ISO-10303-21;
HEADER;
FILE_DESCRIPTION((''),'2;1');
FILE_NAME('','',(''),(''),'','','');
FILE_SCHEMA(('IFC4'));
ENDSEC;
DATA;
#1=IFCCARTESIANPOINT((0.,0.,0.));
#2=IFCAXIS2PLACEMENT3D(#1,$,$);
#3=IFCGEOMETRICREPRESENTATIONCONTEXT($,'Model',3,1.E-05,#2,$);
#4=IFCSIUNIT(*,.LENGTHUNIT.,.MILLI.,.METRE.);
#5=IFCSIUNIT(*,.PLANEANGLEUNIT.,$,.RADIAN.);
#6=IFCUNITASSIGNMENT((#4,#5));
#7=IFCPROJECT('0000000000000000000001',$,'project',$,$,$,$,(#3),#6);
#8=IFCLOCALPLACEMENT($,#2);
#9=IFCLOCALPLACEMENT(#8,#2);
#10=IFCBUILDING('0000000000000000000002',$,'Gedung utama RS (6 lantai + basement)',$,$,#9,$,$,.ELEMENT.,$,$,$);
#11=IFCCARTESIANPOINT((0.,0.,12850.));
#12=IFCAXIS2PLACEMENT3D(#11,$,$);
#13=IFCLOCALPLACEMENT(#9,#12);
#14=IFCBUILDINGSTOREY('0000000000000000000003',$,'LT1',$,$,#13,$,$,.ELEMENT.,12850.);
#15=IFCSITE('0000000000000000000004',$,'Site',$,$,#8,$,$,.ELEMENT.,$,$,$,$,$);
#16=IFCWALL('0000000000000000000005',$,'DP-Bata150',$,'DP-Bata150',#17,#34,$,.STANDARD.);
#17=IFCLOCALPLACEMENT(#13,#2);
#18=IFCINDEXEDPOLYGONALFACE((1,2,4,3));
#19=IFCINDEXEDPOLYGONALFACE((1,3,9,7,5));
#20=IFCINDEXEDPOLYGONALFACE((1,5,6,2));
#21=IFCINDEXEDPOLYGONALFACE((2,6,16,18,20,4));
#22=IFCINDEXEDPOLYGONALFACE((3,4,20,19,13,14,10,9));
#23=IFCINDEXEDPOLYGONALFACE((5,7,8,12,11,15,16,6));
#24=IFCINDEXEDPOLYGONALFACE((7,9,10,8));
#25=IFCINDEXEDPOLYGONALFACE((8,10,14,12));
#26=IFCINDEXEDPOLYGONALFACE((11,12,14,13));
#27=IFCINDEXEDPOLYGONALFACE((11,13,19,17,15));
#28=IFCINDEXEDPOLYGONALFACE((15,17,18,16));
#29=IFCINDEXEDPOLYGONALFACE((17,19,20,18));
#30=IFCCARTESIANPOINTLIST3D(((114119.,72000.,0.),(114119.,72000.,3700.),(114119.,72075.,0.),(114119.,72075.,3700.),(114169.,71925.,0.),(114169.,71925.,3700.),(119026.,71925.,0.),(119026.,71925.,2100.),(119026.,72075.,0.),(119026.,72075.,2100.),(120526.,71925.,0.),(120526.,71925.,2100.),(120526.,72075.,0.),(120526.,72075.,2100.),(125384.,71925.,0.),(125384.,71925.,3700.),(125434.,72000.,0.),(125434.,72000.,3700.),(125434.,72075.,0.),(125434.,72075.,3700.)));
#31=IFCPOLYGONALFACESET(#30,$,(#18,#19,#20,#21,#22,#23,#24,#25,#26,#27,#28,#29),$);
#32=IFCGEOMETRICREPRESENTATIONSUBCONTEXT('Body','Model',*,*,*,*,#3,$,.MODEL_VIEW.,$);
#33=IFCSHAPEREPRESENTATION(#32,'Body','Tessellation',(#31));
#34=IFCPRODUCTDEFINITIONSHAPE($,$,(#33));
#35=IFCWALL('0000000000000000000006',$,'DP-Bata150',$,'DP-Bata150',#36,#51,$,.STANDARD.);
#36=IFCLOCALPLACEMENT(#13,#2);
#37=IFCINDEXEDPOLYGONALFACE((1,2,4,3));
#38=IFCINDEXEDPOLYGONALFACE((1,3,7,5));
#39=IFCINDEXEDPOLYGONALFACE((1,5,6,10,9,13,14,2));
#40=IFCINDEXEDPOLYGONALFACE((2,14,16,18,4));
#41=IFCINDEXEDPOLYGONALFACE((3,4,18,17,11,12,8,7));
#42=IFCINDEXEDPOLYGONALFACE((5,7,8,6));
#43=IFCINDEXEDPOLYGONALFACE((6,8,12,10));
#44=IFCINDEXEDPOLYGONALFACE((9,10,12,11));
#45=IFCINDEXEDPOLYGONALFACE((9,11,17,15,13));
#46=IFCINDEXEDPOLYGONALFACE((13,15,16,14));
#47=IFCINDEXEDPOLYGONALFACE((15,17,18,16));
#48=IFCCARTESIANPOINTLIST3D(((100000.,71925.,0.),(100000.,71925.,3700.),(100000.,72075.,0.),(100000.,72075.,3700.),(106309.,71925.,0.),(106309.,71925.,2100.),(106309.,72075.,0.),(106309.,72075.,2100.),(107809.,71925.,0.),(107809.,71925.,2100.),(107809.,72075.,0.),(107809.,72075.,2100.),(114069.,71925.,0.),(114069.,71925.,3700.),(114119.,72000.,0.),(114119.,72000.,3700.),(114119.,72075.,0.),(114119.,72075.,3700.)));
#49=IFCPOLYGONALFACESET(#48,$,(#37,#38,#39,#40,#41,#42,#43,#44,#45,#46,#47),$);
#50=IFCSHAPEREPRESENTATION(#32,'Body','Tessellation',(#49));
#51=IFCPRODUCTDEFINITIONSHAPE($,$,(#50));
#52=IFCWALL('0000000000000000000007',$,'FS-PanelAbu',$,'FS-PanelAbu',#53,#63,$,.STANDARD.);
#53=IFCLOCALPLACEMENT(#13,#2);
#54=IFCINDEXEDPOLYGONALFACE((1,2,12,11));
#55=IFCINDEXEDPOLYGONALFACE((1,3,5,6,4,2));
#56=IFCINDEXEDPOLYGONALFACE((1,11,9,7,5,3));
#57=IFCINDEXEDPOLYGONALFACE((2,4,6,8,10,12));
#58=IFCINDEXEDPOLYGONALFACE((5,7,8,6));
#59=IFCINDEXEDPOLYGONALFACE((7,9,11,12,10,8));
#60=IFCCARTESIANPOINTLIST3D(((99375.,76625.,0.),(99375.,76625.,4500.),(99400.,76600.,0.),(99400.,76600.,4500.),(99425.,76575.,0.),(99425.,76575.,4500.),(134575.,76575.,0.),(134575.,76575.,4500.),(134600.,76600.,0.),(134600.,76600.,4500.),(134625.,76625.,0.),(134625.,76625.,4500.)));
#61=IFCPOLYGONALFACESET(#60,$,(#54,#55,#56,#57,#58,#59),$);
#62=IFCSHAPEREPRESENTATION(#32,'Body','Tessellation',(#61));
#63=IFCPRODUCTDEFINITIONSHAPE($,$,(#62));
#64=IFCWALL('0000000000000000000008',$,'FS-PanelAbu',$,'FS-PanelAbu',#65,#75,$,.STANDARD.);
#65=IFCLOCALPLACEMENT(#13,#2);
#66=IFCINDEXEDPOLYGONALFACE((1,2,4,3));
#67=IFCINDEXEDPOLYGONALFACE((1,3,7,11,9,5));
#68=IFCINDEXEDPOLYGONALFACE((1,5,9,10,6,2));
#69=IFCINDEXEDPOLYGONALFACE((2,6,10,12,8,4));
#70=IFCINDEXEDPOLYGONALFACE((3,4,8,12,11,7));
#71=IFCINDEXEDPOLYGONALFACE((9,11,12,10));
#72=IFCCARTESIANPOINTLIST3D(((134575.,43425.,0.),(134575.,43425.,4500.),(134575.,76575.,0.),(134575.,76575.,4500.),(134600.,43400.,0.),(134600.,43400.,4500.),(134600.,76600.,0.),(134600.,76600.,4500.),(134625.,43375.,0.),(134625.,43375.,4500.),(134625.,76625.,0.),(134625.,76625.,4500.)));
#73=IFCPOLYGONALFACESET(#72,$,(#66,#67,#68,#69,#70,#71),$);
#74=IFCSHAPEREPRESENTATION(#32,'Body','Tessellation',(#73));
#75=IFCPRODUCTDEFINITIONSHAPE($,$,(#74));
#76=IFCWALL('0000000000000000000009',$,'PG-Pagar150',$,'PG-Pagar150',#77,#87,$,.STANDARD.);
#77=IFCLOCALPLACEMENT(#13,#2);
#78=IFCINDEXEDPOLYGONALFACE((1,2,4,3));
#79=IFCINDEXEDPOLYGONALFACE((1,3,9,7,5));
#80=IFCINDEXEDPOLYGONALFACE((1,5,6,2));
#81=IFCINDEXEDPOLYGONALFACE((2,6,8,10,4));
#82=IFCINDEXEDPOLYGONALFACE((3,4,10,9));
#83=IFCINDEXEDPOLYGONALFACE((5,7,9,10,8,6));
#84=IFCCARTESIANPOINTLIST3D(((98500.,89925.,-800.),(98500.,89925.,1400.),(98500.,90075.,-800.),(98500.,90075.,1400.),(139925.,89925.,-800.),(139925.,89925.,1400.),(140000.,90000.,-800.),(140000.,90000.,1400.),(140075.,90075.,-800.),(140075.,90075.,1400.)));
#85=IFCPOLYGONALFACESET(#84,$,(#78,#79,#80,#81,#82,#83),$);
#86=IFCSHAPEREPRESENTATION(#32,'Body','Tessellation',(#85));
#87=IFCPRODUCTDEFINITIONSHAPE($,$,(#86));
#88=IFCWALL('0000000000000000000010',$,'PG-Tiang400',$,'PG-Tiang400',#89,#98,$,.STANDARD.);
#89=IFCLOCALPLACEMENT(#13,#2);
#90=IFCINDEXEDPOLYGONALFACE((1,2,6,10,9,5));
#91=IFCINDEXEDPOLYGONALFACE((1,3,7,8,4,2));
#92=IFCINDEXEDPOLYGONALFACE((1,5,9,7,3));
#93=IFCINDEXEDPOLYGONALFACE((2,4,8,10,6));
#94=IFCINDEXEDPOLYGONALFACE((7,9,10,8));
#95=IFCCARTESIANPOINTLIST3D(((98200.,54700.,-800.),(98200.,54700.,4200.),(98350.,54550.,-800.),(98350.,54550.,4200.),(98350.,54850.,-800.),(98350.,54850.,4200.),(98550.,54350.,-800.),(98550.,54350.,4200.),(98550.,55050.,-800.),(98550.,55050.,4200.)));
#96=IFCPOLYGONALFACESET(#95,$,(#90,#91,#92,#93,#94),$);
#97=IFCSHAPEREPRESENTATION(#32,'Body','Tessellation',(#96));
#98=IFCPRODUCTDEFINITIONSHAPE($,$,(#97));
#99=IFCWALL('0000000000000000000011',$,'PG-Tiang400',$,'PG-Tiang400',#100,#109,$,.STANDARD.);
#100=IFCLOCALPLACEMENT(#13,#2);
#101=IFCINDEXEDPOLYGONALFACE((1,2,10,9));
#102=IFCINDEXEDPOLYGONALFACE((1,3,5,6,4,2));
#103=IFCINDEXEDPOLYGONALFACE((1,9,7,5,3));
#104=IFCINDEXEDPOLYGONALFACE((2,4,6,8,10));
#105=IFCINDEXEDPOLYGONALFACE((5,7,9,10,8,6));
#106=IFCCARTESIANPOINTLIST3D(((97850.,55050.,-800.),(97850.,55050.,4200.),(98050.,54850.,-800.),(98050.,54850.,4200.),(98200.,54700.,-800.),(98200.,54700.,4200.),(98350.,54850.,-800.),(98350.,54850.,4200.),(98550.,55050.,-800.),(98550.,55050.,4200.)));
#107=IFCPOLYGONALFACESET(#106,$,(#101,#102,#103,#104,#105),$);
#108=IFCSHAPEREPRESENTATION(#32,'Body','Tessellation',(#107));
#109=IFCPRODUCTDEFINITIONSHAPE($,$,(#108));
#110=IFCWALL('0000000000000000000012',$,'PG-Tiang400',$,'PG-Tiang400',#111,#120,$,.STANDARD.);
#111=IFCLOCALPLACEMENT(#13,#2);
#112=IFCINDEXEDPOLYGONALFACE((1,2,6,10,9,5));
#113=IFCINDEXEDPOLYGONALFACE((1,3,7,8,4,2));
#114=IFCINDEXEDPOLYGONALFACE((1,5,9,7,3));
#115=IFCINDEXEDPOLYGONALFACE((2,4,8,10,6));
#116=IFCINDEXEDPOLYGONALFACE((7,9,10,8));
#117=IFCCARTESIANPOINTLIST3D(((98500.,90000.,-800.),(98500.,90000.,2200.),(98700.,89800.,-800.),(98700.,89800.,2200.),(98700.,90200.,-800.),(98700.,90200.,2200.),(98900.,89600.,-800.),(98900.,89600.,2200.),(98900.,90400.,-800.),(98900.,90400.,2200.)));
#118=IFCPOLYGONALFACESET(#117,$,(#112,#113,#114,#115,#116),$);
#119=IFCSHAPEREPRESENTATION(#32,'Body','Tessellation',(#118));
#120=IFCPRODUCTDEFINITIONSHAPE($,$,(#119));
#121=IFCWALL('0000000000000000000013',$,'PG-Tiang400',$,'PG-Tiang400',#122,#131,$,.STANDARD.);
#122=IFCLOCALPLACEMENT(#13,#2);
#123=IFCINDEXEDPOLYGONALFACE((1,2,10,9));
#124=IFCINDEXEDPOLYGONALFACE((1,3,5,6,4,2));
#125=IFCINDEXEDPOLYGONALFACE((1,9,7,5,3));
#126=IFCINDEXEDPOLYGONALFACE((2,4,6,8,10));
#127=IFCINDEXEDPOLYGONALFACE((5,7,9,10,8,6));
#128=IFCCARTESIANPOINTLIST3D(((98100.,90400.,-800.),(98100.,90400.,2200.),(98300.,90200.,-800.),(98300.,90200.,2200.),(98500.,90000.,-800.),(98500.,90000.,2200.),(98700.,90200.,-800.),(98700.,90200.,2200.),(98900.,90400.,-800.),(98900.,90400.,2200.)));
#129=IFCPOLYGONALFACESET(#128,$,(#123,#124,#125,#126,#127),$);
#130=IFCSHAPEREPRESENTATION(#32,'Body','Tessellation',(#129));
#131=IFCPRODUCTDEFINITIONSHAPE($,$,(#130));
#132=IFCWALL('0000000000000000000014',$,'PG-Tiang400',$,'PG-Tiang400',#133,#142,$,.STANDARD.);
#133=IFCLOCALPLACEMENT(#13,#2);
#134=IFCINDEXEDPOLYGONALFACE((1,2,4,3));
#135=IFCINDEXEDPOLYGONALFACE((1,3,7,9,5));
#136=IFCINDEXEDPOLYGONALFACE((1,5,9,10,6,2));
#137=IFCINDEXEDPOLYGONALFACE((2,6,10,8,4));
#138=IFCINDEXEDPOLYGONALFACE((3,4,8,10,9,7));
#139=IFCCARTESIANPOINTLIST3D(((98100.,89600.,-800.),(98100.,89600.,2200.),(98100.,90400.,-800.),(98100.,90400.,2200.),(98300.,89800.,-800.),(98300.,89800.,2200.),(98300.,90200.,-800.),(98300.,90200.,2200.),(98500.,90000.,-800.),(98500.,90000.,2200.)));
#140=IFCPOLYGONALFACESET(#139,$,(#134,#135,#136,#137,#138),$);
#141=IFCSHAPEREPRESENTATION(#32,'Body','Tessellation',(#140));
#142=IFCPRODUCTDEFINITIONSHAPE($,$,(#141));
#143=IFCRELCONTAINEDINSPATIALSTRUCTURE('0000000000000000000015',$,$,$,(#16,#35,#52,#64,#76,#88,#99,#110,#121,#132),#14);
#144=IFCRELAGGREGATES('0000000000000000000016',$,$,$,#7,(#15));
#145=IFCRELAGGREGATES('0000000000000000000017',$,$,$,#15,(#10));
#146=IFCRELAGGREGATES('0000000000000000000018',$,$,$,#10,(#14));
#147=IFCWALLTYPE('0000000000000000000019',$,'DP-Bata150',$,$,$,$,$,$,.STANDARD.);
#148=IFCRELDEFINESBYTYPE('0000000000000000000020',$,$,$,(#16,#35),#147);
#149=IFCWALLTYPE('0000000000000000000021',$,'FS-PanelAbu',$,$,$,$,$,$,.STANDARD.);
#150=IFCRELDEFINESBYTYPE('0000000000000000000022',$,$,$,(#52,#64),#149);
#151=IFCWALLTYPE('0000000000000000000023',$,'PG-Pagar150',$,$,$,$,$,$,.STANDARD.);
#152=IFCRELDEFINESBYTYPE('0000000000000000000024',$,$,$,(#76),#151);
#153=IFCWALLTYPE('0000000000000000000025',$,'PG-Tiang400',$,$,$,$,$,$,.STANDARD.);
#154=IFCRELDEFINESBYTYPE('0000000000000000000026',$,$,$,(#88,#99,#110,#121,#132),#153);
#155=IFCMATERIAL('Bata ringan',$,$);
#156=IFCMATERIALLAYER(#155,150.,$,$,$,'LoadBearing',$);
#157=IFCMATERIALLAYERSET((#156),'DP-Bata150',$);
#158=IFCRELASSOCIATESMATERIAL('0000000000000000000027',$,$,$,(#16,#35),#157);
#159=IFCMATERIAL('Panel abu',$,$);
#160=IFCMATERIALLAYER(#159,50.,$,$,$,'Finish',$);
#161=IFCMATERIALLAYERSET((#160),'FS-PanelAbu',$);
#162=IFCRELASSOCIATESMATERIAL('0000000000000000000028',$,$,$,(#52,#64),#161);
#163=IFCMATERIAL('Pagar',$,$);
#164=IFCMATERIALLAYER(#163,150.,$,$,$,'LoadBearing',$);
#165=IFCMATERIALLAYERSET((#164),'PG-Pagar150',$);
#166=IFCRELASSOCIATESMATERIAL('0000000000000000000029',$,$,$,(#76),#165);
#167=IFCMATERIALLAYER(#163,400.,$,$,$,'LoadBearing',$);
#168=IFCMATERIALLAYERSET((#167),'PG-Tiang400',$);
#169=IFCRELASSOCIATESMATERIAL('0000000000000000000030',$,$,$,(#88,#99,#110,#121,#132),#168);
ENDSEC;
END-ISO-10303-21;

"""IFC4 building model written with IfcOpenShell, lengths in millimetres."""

from ifc_helpers import new_model, si_unit, frame, frame_2d, origin, place, context, subcontext, project, spatial, polyline, rectangle, outline, extrude, material, layer, layer_set, layer_usage, type_object, element, save


model = new_model("IFC4")

# Units and contexts
model_context = context("Model", 3, precision=1e-05, world=origin())
body_context = subcontext(model_context, "Body", "Model", "MODEL_VIEW")
ifc_project = project(units=[si_unit("LENGTHUNIT", "METRE", prefix="MILLI"), si_unit("PLANEANGLEUNIT", "RADIAN")], contexts=[model_context])

# Site, building, storey
site_placement = place(None, origin())
site = spatial("IfcSite", under=ifc_project, at=site_placement, Name="Site", CompositionType="ELEMENT")
building_placement = place(site_placement, origin())
building = spatial("IfcBuilding", under=site, at=building_placement, Name="Gedung utama RS (6 lantai + basement)", CompositionType="ELEMENT")
storey_placement = place(building_placement, frame((0.0, 0.0, 12850.0)))
storey = spatial("IfcBuildingStorey", under=building, at=storey_placement, Name="LT1", CompositionType="ELEMENT", Elevation=12850.0)

# Shared definitions
ifc_material_1 = material(Name="Bata ringan")
ifc_layer_1 = layer(ifc_material_1, 150.0, Category="LoadBearing")
ifc_layer_set_1 = layer_set([ifc_layer_1], Name="DP-Bata150")
ifc_layer_usage_1 = layer_usage(ifc_layer_set_1, "AXIS2", "NEGATIVE", 75.0)
wall_type_1 = type_object("IfcWallType", Name="DP-Bata150", PredefinedType="STANDARD")

# Walls, openings
wall_1_placement = place(storey_placement, frame((125434.0, 72000.0, 0.0), z_axis=(0.0, 0.0, 1.0), x_axis=(-1.0, 0.0, 0.0)))
wall_1 = element("IfcWall", 1, at=wall_1_placement, inside=storey, type_object=wall_type_1, material=ifc_layer_usage_1, Name="DP-Bata150", ObjectType="DP-Bata150", PredefinedType="STANDARD", context=body_context, shape_type="SweptSolid", body=[
    extrude(outline(polyline([(0.0, -75.0), (0.0, 0.0), (50.0, 75.0), (11265.0, 75.0), (11315.0, 0.0), (11315.0, -75.0), (0.0, -75.0)])), origin(), (0.0, 0.0, 1.0), 3700.0),
])
opening_1_placement = place(wall_1_placement, frame((4908.0, 0.0, 0.0), z_axis=(0.0, 0.0, 1.0), x_axis=(1.0, 0.0, 0.0)))
element("IfcOpeningElement", 2, at=opening_1_placement, cuts=wall_1, PredefinedType="OPENING", context=body_context, shape_type="SweptSolid", body=[
    extrude(rectangle(XDim=1500.0, YDim=170.0, at=frame_2d((750.0, 0.0))), origin(), (0.0, 0.0, 1.0), 2100.0),
])
wall_2_placement = place(storey_placement, frame((114119.0, 72000.0, 0.0), z_axis=(0.0, 0.0, 1.0), x_axis=(-1.0, 0.0, 0.0)))
wall_2 = element("IfcWall", 3, at=wall_2_placement, inside=storey, type_object=wall_type_1, material=ifc_layer_usage_1, Name="DP-Bata150", ObjectType="DP-Bata150", PredefinedType="STANDARD", context=body_context, shape_type="SweptSolid", body=[
    extrude(outline(polyline([(0.0, -75.0), (0.0, 0.0), (50.0, 75.0), (14119.0, 75.0), (14119.0, -75.0), (0.0, -75.0)])), origin(), (0.0, 0.0, 1.0), 3700.0),
])
opening_2_placement = place(wall_2_placement, frame((6310.0, 0.0, 0.0), z_axis=(0.0, 0.0, 1.0), x_axis=(1.0, 0.0, 0.0)))
element("IfcOpeningElement", 4, at=opening_2_placement, cuts=wall_2, PredefinedType="OPENING", context=body_context, shape_type="SweptSolid", body=[
    extrude(rectangle(XDim=1500.0, YDim=170.0, at=frame_2d((750.0, 0.0))), origin(), (0.0, 0.0, 1.0), 2100.0),
])

# Walls
ifc_material_2 = material(Name="Panel abu")
ifc_layer_2 = layer(ifc_material_2, 50.0, Category="Finish")
ifc_layer_set_2 = layer_set([ifc_layer_2], Name="FS-PanelAbu")
ifc_layer_usage_2 = layer_usage(ifc_layer_set_2, "AXIS2", "NEGATIVE", 25.0)
wall_type_2 = type_object("IfcWallType", Name="FS-PanelAbu", PredefinedType="STANDARD")
wall_3_placement = place(storey_placement, frame((99400.0, 76600.0, 0.0), z_axis=(0.0, 0.0, 1.0), x_axis=(1.0, 0.0, 0.0)))
element("IfcWall", 5, at=wall_3_placement, inside=storey, type_object=wall_type_2, material=ifc_layer_usage_2, Name="FS-PanelAbu", ObjectType="FS-PanelAbu", PredefinedType="STANDARD", context=body_context, shape_type="SweptSolid", body=[
    extrude(outline(polyline([(25.0, -25.0), (0.0, 0.0), (-25.0, 25.0), (35225.0, 25.0), (35200.0, 0.0), (35175.0, -25.0), (25.0, -25.0)])), origin(), (0.0, 0.0, 1.0), 4500.0),
])
wall_4_placement = place(storey_placement, frame((134600.0, 76600.0, 0.0), z_axis=(0.0, 0.0, 1.0), x_axis=(0.0, -1.0, 0.0)))
element("IfcWall", 6, at=wall_4_placement, inside=storey, type_object=wall_type_2, material=ifc_layer_usage_2, Name="FS-PanelAbu", ObjectType="FS-PanelAbu", PredefinedType="STANDARD", context=body_context, shape_type="SweptSolid", body=[
    extrude(outline(polyline([(25.0, -25.0), (0.0, 0.0), (-25.0, 25.0), (33225.0, 25.0), (33200.0, 0.0), (33175.0, -25.0), (25.0, -25.0)])), origin(), (0.0, 0.0, 1.0), 4500.0),
])
ifc_material_3 = material(Name="Pagar")
ifc_layer_3 = layer(ifc_material_3, 150.0, Category="LoadBearing")
ifc_layer_set_3 = layer_set([ifc_layer_3], Name="PG-Pagar150")
ifc_layer_usage_3 = layer_usage(ifc_layer_set_3, "AXIS2", "NEGATIVE", 75.0)
wall_type_3 = type_object("IfcWallType", Name="PG-Pagar150", PredefinedType="STANDARD")
wall_5_placement = place(storey_placement, frame((140000.0, 90000.0, -800.0), z_axis=(0.0, 0.0, 1.0), x_axis=(-1.0, 0.0, 0.0)))
element("IfcWall", 7, at=wall_5_placement, inside=storey, type_object=wall_type_3, material=ifc_layer_usage_3, Name="PG-Pagar150", ObjectType="PG-Pagar150", PredefinedType="STANDARD", context=body_context, shape_type="SweptSolid", body=[
    extrude(outline(polyline([(-75.0, -75.0), (0.0, 0.0), (75.0, 75.0), (41500.0, 75.0), (41500.0, -75.0), (-75.0, -75.0)])), origin(), (0.0, 0.0, 1.0), 2200.0),
])
ifc_layer_4 = layer(ifc_material_3, 400.0, Category="LoadBearing")
ifc_layer_set_4 = layer_set([ifc_layer_4], Name="PG-Tiang400")
ifc_layer_usage_4 = layer_usage(ifc_layer_set_4, "AXIS2", "NEGATIVE", 200.0)
wall_type_4 = type_object("IfcWallType", Name="PG-Tiang400", PredefinedType="STANDARD")
for number, where, z_axis, x_axis, name in (
    (8, (98350.0, 54550.0, -800.0), (0.0, 0.0, 1.0), (0.0, 1.0, 0.0), "PG-Tiang400"),
    (9, (98350.0, 54850.0, -800.0), (0.0, 0.0, 1.0), (-1.0, 0.0, 0.0), "PG-Tiang400"),
):
    element("IfcWall", number, at=place(storey_placement, frame(where, z_axis=z_axis, x_axis=x_axis)), inside=storey, type_object=wall_type_4, material=ifc_layer_usage_4, Name=name, ObjectType="PG-Tiang400", PredefinedType="STANDARD", context=body_context, shape_type="SweptSolid", body=[
        extrude(outline(polyline([(-200.0, -200.0), (0.0, 0.0), (200.0, 200.0), (100.0, 200.0), (300.0, 0.0), (500.0, -200.0), (-200.0, -200.0)])), origin(), (0.0, 0.0, 1.0), 5000.0),
    ])
for number, where, z_axis, x_axis, name in (
    (10, (98700.0, 89800.0, -800.0), (0.0, 0.0, 1.0), (0.0, 1.0, 0.0), "PG-Tiang400"),
    (11, (98700.0, 90200.0, -800.0), (0.0, 0.0, 1.0), (-1.0, 0.0, 0.0), "PG-Tiang400"),
    (12, (98300.0, 90200.0, -800.0), (0.0, 0.0, 1.0), (0.0, -1.0, 0.0), "PG-Tiang400"),
):
    element("IfcWall", number, at=place(storey_placement, frame(where, z_axis=z_axis, x_axis=x_axis)), inside=storey, type_object=wall_type_4, material=ifc_layer_usage_4, Name=name, ObjectType="PG-Tiang400", PredefinedType="STANDARD", context=body_context, shape_type="SweptSolid", body=[
        extrude(outline(polyline([(-200.0, -200.0), (0.0, 0.0), (200.0, 200.0), (400.0, 0.0), (600.0, -200.0), (-200.0, -200.0)])), origin(), (0.0, 0.0, 1.0), 3000.0),
    ])

save(model, "model.ifc")
